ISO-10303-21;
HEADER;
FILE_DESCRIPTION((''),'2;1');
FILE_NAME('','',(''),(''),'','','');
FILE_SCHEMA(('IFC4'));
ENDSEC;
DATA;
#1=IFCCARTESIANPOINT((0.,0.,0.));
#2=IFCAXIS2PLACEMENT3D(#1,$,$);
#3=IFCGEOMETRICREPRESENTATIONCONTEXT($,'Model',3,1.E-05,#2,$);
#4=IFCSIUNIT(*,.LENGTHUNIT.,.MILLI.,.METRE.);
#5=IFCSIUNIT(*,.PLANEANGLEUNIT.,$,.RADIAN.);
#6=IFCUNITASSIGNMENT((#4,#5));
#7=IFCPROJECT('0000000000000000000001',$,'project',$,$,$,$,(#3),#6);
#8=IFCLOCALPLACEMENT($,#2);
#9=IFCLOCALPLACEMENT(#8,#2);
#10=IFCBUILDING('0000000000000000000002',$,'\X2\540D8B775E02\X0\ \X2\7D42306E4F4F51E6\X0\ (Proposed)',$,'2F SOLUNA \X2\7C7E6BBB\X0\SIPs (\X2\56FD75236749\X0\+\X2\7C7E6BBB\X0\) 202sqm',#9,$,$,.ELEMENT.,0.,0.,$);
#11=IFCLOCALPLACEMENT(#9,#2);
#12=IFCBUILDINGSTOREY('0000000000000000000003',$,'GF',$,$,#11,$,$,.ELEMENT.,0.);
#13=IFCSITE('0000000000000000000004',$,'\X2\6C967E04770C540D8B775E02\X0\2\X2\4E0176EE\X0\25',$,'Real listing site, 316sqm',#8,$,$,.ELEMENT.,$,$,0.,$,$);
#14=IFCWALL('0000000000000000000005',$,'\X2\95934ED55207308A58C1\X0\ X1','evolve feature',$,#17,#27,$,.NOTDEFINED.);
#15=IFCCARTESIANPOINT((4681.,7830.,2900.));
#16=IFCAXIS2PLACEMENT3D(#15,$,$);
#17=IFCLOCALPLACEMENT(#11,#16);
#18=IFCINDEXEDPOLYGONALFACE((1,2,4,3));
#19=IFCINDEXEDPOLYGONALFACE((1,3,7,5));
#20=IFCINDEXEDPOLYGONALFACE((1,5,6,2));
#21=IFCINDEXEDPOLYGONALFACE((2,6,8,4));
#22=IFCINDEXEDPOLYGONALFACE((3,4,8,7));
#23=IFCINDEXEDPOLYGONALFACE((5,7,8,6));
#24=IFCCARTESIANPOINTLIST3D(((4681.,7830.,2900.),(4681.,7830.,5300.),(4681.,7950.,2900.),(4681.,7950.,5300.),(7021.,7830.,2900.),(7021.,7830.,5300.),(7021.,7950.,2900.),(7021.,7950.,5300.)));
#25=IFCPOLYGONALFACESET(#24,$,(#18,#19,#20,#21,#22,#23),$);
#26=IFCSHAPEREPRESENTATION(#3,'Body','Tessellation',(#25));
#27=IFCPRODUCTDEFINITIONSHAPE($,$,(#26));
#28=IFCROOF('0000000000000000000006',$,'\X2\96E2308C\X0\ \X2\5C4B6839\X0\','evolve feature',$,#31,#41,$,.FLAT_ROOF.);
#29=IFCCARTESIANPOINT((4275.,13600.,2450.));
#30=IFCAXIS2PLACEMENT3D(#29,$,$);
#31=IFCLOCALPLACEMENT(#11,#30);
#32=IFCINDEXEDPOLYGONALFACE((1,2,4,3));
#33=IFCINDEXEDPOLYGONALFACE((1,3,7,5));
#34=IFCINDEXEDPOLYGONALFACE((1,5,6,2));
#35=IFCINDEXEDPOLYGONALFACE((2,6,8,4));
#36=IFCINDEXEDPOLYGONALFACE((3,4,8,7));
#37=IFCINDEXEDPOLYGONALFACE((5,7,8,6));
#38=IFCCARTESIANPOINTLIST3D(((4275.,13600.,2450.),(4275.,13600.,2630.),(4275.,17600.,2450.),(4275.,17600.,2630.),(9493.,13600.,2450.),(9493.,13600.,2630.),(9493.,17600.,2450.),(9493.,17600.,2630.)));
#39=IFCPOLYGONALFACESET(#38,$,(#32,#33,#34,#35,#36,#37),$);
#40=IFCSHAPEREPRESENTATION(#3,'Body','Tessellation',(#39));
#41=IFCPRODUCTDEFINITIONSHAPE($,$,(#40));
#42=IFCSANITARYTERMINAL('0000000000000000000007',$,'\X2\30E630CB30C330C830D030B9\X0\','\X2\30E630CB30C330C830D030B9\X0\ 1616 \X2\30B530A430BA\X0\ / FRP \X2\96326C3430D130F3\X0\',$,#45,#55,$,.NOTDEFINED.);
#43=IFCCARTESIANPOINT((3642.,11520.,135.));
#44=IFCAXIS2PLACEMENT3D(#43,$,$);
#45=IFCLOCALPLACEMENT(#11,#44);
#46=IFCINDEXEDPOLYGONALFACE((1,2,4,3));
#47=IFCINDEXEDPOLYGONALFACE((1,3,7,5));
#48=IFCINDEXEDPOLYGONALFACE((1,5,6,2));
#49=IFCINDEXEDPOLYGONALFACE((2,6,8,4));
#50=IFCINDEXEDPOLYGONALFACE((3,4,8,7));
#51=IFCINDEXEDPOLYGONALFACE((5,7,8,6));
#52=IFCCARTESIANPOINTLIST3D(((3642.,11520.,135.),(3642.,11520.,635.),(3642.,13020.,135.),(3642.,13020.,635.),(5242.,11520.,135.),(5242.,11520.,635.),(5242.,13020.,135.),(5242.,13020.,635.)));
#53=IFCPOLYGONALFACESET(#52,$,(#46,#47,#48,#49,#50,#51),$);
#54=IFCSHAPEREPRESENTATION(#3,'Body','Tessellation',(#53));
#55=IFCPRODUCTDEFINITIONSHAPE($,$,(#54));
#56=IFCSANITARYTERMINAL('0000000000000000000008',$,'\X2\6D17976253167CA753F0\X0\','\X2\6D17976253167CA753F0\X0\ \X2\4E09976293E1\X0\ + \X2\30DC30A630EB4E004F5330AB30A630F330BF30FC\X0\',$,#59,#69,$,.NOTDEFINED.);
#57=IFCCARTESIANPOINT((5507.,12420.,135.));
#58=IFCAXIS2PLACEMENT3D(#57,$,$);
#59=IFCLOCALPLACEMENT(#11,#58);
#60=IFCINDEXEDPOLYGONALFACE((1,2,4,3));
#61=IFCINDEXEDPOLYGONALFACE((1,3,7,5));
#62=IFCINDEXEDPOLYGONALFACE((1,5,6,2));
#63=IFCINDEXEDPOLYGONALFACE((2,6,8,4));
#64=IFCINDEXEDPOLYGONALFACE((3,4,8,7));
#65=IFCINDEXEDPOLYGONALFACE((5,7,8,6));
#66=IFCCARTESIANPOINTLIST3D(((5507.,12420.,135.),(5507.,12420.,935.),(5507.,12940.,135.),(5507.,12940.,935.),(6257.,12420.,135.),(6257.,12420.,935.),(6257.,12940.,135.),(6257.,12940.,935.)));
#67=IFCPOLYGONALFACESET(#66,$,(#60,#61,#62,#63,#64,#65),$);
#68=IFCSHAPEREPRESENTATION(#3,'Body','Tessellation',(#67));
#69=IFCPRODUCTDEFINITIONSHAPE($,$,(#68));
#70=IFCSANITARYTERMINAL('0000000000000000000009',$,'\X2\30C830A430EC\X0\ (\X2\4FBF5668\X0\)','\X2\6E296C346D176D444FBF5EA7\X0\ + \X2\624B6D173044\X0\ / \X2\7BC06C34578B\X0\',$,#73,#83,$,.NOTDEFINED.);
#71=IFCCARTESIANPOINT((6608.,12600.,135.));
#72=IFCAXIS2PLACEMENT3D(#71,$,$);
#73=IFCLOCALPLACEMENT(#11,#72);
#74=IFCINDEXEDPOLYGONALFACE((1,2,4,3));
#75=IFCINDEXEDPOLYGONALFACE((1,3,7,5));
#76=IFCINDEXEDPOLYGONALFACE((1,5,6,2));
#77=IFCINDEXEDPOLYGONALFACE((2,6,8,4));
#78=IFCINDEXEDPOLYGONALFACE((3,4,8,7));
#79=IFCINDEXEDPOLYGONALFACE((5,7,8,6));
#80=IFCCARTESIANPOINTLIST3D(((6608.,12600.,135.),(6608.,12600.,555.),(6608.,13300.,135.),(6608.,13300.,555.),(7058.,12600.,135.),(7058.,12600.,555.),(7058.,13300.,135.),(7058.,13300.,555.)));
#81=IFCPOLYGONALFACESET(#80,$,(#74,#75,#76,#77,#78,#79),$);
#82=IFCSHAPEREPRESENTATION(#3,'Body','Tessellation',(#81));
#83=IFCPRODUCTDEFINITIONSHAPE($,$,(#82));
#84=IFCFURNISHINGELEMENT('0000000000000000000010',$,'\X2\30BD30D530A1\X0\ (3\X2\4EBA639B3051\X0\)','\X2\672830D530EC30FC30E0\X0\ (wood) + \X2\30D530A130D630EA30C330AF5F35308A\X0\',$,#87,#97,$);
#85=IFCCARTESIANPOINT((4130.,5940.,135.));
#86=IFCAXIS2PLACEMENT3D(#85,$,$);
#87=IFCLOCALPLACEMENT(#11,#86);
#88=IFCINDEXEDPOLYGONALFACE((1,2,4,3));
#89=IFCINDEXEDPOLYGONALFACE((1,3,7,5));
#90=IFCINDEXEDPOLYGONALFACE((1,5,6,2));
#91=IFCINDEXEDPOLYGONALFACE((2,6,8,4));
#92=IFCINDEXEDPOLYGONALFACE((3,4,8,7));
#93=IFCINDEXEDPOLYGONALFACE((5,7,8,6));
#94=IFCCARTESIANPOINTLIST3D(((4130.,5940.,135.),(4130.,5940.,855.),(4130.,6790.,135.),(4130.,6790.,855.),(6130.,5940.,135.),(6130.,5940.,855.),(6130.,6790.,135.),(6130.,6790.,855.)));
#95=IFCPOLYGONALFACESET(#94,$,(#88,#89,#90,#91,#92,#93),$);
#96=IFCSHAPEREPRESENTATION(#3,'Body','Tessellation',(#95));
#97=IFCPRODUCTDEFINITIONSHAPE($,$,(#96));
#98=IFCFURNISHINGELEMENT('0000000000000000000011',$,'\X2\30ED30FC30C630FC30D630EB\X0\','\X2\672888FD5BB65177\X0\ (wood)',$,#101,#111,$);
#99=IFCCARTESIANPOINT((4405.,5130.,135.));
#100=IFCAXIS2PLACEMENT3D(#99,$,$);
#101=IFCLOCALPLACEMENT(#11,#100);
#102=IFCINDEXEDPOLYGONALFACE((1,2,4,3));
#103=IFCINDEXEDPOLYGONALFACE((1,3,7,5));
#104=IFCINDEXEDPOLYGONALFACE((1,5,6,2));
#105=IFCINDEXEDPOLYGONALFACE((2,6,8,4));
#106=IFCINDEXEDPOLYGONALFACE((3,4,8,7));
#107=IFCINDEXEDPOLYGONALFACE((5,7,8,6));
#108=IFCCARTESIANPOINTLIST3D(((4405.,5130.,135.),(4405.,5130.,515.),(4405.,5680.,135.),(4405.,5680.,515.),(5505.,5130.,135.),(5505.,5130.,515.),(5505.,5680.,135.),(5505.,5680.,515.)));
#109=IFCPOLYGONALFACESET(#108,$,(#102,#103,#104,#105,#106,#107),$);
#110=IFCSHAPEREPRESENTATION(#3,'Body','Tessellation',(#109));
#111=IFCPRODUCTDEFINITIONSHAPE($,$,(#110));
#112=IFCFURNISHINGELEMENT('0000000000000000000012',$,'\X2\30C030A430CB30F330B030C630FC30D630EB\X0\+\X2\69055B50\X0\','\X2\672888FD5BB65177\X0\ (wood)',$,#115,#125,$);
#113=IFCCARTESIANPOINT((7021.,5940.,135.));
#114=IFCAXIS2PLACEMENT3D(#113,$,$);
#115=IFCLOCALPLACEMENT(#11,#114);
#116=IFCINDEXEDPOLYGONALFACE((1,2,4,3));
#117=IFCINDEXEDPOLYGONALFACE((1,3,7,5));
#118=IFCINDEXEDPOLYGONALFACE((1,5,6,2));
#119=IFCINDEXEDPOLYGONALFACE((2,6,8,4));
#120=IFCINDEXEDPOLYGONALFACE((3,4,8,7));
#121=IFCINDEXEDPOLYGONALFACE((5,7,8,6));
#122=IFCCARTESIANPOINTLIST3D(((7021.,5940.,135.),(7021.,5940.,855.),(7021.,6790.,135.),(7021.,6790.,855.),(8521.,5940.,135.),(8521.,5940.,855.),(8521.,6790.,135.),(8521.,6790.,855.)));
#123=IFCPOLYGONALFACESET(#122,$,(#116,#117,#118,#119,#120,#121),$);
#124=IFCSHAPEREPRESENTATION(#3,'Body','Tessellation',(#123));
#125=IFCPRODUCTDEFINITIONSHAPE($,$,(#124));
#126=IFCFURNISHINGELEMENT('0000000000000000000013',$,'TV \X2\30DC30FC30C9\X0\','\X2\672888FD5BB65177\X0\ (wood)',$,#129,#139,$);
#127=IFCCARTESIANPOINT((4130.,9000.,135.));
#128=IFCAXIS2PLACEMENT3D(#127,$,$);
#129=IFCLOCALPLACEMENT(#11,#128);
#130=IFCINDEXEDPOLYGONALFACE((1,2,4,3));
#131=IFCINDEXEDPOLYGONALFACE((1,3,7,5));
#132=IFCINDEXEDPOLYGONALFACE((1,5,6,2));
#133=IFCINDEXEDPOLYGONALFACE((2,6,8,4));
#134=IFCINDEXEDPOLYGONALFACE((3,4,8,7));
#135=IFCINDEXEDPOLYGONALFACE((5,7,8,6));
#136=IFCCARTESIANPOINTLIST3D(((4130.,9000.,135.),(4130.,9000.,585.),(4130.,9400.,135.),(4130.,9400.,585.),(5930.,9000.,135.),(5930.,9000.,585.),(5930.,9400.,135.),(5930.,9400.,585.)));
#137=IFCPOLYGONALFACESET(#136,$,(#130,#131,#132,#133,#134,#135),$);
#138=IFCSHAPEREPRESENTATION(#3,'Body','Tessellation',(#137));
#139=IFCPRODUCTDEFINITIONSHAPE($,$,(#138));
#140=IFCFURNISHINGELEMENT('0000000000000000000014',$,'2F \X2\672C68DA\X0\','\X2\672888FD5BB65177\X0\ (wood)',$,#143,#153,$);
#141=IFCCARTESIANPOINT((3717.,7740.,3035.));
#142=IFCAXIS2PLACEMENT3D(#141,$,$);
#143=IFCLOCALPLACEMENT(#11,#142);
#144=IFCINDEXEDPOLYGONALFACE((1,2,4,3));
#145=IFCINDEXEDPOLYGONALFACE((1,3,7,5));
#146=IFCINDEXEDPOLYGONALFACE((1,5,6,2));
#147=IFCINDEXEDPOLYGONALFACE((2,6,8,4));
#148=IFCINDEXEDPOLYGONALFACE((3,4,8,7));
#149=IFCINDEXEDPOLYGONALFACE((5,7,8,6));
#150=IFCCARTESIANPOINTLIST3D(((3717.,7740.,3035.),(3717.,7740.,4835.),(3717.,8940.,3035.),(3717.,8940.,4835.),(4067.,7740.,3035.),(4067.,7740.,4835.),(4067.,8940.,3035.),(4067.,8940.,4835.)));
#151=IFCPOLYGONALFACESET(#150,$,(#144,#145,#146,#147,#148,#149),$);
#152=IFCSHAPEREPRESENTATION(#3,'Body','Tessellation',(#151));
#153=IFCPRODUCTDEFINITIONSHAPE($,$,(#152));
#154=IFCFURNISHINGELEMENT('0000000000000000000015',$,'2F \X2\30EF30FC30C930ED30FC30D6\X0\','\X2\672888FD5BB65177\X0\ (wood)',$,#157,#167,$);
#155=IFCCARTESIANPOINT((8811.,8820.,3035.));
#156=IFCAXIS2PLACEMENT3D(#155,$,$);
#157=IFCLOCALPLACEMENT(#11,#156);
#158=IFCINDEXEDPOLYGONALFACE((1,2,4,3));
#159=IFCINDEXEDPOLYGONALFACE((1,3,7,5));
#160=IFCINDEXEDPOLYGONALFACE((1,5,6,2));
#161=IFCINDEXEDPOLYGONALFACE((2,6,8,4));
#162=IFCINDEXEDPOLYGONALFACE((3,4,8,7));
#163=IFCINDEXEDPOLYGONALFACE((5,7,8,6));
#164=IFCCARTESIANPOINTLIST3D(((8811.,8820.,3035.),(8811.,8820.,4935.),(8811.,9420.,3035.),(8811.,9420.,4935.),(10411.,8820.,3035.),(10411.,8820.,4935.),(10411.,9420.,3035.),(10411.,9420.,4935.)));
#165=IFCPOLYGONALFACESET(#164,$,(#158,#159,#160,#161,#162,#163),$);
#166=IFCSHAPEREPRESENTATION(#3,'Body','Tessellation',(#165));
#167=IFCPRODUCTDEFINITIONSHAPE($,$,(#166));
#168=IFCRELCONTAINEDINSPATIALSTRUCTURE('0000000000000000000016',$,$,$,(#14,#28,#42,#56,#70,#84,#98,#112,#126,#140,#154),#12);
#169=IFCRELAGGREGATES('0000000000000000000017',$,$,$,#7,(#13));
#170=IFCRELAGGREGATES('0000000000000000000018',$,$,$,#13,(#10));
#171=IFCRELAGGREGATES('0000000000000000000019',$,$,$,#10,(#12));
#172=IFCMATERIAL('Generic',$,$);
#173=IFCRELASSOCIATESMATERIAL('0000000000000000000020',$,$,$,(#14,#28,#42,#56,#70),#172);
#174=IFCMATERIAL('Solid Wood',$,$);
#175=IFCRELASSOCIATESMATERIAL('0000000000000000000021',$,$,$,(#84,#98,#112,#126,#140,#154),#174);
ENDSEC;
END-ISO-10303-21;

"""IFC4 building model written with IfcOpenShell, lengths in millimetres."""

from ifc_helpers import new_model, si_unit, frame, frame_2d, origin, place, context, project, spatial, rectangle, extrude, material, element, save


model = new_model("IFC4")

# Units and contexts
model_context = context("Model", 3, precision=1e-05, world=origin())
ifc_project = project(units=[si_unit("LENGTHUNIT", "METRE", prefix="MILLI"), si_unit("PLANEANGLEUNIT", "RADIAN")], contexts=[model_context])

# Site, building, storey
site_placement = place(None, origin())
site = spatial("IfcSite", under=ifc_project, at=site_placement, Name="沖縄県名護市2丁目25", ObjectType="Real listing site, 316sqm", CompositionType="ELEMENT", RefElevation=0.0)
building_placement = place(site_placement, origin())
building = spatial("IfcBuilding", under=site, at=building_placement, Name="名護市 終の住処 (Proposed)", ObjectType="2F SOLUNA 籾殻SIPs (国産杉+籾殻) 202sqm", CompositionType="ELEMENT", ElevationOfRefHeight=0.0, ElevationOfTerrain=0.0)
storey_placement = place(building_placement, origin())
storey = spatial("IfcBuildingStorey", under=building, at=storey_placement, Name="GF", CompositionType="ELEMENT", Elevation=0.0)

# Shared definitions
ifc_material_1 = material(Name="Generic")

# Shared definitions
ifc_material_2 = material(Name="Solid Wood")

# Wall
wall_1_placement = place(storey_placement, frame((4681.0, 7830.0, 2900.0)))
element("IfcWall", 1, at=wall_1_placement, inside=storey, material=ifc_material_1, Name="間仕切り壁 X1", Description="evolve feature", PredefinedType="NOTDEFINED", context=model_context, shape_type="SweptSolid", body=[
    extrude(rectangle(XDim=2340.0, YDim=120.0, at=frame_2d((1170.0, 60.0))), frame((4681.0, 7830.0, 2900.0)), (0.0, 0.0, 1.0), 2400.0),
])

# Roof
roof_placement = place(storey_placement, frame((4275.0, 13600.0, 2450.0)))
element("IfcRoof", 2, at=roof_placement, inside=storey, material=ifc_material_1, Name="離れ 屋根", Description="evolve feature", PredefinedType="FLAT_ROOF", context=model_context, shape_type="SweptSolid", body=[
    extrude(rectangle(XDim=5218.0, YDim=4000.0, at=frame_2d((2609.0, 2000.0))), frame((4275.0, 13600.0, 2450.0)), (0.0, 0.0, 1.0), 180.0),
])

# Sanitary terminals
sanitary_terminal_1_placement = place(storey_placement, frame((3642.0, 11520.0, 135.0)))
element("IfcSanitaryTerminal", 3, at=sanitary_terminal_1_placement, inside=storey, material=ifc_material_1, Name="ユニットバス", Description="ユニットバス 1616 サイズ / FRP 防水パン", PredefinedType="NOTDEFINED", context=model_context, shape_type="SweptSolid", body=[
    extrude(rectangle(XDim=1600.0, YDim=1500.0, at=frame_2d((800.0, 750.0))), frame((3642.0, 11520.0, 135.0)), (0.0, 0.0, 1.0), 500.0),
])
sanitary_terminal_2_placement = place(storey_placement, frame((5507.0, 12420.0, 135.0)))
element("IfcSanitaryTerminal", 4, at=sanitary_terminal_2_placement, inside=storey, material=ifc_material_1, Name="洗面化粧台", Description="洗面化粧台 三面鏡 + ボウル一体カウンター", PredefinedType="NOTDEFINED", context=model_context, shape_type="SweptSolid", body=[
    extrude(rectangle(XDim=750.0, YDim=520.0, at=frame_2d((375.0, 260.0))), frame((5507.0, 12420.0, 135.0)), (0.0, 0.0, 1.0), 800.0),
])
sanitary_terminal_3_placement = place(storey_placement, frame((6608.0, 12600.0, 135.0)))
element("IfcSanitaryTerminal", 5, at=sanitary_terminal_3_placement, inside=storey, material=ifc_material_1, Name="トイレ (便器)", Description="温水洗浄便座 + 手洗い / 節水型", PredefinedType="NOTDEFINED", context=model_context, shape_type="SweptSolid", body=[
    extrude(rectangle(XDim=450.0, YDim=700.0, at=frame_2d((225.0, 350.0))), frame((6608.0, 12600.0, 135.0)), (0.0, 0.0, 1.0), 420.0),
])

# Furnishing elements
furnishing_1_placement = place(storey_placement, frame((4130.0, 5940.0, 135.0)))
element("IfcFurnishingElement", 6, at=furnishing_1_placement, inside=storey, material=ifc_material_2, Name="ソファ (3人掛け)", Description="木フレーム (wood) + ファブリック張り", context=model_context, shape_type="SweptSolid", body=[
    extrude(rectangle(XDim=2000.0, YDim=850.0, at=frame_2d((1000.0, 425.0))), frame((4130.0, 5940.0, 135.0)), (0.0, 0.0, 1.0), 720.0),
])
furnishing_2_placement = place(storey_placement, frame((4405.0, 5130.0, 135.0)))
element("IfcFurnishingElement", 7, at=furnishing_2_placement, inside=storey, material=ifc_material_2, Name="ローテーブル", Description="木製家具 (wood)", context=model_context, shape_type="SweptSolid", body=[
    extrude(rectangle(XDim=1100.0, YDim=550.0, at=frame_2d((550.0, 275.0))), frame((4405.0, 5130.0, 135.0)), (0.0, 0.0, 1.0), 380.0),
])
furnishing_3_placement = place(storey_placement, frame((7021.0, 5940.0, 135.0)))
element("IfcFurnishingElement", 8, at=furnishing_3_placement, inside=storey, material=ifc_material_2, Name="ダイニングテーブル+椅子", Description="木製家具 (wood)", context=model_context, shape_type="SweptSolid", body=[
    extrude(rectangle(XDim=1500.0, YDim=850.0, at=frame_2d((750.0, 425.0))), frame((7021.0, 5940.0, 135.0)), (0.0, 0.0, 1.0), 720.0),
])
furnishing_4_placement = place(storey_placement, frame((4130.0, 9000.0, 135.0)))
element("IfcFurnishingElement", 9, at=furnishing_4_placement, inside=storey, material=ifc_material_2, Name="TV ボード", Description="木製家具 (wood)", context=model_context, shape_type="SweptSolid", body=[
    extrude(rectangle(XDim=1800.0, YDim=400.0, at=frame_2d((900.0, 200.0))), frame((4130.0, 9000.0, 135.0)), (0.0, 0.0, 1.0), 450.0),
])
furnishing_5_placement = place(storey_placement, frame((3717.0, 7740.0, 3035.0)))
element("IfcFurnishingElement", 10, at=furnishing_5_placement, inside=storey, material=ifc_material_2, Name="2F 本棚", Description="木製家具 (wood)", context=model_context, shape_type="SweptSolid", body=[
    extrude(rectangle(XDim=350.0, YDim=1200.0, at=frame_2d((175.0, 600.0))), frame((3717.0, 7740.0, 3035.0)), (0.0, 0.0, 1.0), 1800.0),
])
furnishing_6_placement = place(storey_placement, frame((8811.0, 8820.0, 3035.0)))
element("IfcFurnishingElement", 11, at=furnishing_6_placement, inside=storey, material=ifc_material_2, Name="2F ワードローブ", Description="木製家具 (wood)", context=model_context, shape_type="SweptSolid", body=[
    extrude(rectangle(XDim=1600.0, YDim=600.0, at=frame_2d((800.0, 300.0))), frame((8811.0, 8820.0, 3035.0)), (0.0, 0.0, 1.0), 1900.0),
])

save(model, "model.ifc")
